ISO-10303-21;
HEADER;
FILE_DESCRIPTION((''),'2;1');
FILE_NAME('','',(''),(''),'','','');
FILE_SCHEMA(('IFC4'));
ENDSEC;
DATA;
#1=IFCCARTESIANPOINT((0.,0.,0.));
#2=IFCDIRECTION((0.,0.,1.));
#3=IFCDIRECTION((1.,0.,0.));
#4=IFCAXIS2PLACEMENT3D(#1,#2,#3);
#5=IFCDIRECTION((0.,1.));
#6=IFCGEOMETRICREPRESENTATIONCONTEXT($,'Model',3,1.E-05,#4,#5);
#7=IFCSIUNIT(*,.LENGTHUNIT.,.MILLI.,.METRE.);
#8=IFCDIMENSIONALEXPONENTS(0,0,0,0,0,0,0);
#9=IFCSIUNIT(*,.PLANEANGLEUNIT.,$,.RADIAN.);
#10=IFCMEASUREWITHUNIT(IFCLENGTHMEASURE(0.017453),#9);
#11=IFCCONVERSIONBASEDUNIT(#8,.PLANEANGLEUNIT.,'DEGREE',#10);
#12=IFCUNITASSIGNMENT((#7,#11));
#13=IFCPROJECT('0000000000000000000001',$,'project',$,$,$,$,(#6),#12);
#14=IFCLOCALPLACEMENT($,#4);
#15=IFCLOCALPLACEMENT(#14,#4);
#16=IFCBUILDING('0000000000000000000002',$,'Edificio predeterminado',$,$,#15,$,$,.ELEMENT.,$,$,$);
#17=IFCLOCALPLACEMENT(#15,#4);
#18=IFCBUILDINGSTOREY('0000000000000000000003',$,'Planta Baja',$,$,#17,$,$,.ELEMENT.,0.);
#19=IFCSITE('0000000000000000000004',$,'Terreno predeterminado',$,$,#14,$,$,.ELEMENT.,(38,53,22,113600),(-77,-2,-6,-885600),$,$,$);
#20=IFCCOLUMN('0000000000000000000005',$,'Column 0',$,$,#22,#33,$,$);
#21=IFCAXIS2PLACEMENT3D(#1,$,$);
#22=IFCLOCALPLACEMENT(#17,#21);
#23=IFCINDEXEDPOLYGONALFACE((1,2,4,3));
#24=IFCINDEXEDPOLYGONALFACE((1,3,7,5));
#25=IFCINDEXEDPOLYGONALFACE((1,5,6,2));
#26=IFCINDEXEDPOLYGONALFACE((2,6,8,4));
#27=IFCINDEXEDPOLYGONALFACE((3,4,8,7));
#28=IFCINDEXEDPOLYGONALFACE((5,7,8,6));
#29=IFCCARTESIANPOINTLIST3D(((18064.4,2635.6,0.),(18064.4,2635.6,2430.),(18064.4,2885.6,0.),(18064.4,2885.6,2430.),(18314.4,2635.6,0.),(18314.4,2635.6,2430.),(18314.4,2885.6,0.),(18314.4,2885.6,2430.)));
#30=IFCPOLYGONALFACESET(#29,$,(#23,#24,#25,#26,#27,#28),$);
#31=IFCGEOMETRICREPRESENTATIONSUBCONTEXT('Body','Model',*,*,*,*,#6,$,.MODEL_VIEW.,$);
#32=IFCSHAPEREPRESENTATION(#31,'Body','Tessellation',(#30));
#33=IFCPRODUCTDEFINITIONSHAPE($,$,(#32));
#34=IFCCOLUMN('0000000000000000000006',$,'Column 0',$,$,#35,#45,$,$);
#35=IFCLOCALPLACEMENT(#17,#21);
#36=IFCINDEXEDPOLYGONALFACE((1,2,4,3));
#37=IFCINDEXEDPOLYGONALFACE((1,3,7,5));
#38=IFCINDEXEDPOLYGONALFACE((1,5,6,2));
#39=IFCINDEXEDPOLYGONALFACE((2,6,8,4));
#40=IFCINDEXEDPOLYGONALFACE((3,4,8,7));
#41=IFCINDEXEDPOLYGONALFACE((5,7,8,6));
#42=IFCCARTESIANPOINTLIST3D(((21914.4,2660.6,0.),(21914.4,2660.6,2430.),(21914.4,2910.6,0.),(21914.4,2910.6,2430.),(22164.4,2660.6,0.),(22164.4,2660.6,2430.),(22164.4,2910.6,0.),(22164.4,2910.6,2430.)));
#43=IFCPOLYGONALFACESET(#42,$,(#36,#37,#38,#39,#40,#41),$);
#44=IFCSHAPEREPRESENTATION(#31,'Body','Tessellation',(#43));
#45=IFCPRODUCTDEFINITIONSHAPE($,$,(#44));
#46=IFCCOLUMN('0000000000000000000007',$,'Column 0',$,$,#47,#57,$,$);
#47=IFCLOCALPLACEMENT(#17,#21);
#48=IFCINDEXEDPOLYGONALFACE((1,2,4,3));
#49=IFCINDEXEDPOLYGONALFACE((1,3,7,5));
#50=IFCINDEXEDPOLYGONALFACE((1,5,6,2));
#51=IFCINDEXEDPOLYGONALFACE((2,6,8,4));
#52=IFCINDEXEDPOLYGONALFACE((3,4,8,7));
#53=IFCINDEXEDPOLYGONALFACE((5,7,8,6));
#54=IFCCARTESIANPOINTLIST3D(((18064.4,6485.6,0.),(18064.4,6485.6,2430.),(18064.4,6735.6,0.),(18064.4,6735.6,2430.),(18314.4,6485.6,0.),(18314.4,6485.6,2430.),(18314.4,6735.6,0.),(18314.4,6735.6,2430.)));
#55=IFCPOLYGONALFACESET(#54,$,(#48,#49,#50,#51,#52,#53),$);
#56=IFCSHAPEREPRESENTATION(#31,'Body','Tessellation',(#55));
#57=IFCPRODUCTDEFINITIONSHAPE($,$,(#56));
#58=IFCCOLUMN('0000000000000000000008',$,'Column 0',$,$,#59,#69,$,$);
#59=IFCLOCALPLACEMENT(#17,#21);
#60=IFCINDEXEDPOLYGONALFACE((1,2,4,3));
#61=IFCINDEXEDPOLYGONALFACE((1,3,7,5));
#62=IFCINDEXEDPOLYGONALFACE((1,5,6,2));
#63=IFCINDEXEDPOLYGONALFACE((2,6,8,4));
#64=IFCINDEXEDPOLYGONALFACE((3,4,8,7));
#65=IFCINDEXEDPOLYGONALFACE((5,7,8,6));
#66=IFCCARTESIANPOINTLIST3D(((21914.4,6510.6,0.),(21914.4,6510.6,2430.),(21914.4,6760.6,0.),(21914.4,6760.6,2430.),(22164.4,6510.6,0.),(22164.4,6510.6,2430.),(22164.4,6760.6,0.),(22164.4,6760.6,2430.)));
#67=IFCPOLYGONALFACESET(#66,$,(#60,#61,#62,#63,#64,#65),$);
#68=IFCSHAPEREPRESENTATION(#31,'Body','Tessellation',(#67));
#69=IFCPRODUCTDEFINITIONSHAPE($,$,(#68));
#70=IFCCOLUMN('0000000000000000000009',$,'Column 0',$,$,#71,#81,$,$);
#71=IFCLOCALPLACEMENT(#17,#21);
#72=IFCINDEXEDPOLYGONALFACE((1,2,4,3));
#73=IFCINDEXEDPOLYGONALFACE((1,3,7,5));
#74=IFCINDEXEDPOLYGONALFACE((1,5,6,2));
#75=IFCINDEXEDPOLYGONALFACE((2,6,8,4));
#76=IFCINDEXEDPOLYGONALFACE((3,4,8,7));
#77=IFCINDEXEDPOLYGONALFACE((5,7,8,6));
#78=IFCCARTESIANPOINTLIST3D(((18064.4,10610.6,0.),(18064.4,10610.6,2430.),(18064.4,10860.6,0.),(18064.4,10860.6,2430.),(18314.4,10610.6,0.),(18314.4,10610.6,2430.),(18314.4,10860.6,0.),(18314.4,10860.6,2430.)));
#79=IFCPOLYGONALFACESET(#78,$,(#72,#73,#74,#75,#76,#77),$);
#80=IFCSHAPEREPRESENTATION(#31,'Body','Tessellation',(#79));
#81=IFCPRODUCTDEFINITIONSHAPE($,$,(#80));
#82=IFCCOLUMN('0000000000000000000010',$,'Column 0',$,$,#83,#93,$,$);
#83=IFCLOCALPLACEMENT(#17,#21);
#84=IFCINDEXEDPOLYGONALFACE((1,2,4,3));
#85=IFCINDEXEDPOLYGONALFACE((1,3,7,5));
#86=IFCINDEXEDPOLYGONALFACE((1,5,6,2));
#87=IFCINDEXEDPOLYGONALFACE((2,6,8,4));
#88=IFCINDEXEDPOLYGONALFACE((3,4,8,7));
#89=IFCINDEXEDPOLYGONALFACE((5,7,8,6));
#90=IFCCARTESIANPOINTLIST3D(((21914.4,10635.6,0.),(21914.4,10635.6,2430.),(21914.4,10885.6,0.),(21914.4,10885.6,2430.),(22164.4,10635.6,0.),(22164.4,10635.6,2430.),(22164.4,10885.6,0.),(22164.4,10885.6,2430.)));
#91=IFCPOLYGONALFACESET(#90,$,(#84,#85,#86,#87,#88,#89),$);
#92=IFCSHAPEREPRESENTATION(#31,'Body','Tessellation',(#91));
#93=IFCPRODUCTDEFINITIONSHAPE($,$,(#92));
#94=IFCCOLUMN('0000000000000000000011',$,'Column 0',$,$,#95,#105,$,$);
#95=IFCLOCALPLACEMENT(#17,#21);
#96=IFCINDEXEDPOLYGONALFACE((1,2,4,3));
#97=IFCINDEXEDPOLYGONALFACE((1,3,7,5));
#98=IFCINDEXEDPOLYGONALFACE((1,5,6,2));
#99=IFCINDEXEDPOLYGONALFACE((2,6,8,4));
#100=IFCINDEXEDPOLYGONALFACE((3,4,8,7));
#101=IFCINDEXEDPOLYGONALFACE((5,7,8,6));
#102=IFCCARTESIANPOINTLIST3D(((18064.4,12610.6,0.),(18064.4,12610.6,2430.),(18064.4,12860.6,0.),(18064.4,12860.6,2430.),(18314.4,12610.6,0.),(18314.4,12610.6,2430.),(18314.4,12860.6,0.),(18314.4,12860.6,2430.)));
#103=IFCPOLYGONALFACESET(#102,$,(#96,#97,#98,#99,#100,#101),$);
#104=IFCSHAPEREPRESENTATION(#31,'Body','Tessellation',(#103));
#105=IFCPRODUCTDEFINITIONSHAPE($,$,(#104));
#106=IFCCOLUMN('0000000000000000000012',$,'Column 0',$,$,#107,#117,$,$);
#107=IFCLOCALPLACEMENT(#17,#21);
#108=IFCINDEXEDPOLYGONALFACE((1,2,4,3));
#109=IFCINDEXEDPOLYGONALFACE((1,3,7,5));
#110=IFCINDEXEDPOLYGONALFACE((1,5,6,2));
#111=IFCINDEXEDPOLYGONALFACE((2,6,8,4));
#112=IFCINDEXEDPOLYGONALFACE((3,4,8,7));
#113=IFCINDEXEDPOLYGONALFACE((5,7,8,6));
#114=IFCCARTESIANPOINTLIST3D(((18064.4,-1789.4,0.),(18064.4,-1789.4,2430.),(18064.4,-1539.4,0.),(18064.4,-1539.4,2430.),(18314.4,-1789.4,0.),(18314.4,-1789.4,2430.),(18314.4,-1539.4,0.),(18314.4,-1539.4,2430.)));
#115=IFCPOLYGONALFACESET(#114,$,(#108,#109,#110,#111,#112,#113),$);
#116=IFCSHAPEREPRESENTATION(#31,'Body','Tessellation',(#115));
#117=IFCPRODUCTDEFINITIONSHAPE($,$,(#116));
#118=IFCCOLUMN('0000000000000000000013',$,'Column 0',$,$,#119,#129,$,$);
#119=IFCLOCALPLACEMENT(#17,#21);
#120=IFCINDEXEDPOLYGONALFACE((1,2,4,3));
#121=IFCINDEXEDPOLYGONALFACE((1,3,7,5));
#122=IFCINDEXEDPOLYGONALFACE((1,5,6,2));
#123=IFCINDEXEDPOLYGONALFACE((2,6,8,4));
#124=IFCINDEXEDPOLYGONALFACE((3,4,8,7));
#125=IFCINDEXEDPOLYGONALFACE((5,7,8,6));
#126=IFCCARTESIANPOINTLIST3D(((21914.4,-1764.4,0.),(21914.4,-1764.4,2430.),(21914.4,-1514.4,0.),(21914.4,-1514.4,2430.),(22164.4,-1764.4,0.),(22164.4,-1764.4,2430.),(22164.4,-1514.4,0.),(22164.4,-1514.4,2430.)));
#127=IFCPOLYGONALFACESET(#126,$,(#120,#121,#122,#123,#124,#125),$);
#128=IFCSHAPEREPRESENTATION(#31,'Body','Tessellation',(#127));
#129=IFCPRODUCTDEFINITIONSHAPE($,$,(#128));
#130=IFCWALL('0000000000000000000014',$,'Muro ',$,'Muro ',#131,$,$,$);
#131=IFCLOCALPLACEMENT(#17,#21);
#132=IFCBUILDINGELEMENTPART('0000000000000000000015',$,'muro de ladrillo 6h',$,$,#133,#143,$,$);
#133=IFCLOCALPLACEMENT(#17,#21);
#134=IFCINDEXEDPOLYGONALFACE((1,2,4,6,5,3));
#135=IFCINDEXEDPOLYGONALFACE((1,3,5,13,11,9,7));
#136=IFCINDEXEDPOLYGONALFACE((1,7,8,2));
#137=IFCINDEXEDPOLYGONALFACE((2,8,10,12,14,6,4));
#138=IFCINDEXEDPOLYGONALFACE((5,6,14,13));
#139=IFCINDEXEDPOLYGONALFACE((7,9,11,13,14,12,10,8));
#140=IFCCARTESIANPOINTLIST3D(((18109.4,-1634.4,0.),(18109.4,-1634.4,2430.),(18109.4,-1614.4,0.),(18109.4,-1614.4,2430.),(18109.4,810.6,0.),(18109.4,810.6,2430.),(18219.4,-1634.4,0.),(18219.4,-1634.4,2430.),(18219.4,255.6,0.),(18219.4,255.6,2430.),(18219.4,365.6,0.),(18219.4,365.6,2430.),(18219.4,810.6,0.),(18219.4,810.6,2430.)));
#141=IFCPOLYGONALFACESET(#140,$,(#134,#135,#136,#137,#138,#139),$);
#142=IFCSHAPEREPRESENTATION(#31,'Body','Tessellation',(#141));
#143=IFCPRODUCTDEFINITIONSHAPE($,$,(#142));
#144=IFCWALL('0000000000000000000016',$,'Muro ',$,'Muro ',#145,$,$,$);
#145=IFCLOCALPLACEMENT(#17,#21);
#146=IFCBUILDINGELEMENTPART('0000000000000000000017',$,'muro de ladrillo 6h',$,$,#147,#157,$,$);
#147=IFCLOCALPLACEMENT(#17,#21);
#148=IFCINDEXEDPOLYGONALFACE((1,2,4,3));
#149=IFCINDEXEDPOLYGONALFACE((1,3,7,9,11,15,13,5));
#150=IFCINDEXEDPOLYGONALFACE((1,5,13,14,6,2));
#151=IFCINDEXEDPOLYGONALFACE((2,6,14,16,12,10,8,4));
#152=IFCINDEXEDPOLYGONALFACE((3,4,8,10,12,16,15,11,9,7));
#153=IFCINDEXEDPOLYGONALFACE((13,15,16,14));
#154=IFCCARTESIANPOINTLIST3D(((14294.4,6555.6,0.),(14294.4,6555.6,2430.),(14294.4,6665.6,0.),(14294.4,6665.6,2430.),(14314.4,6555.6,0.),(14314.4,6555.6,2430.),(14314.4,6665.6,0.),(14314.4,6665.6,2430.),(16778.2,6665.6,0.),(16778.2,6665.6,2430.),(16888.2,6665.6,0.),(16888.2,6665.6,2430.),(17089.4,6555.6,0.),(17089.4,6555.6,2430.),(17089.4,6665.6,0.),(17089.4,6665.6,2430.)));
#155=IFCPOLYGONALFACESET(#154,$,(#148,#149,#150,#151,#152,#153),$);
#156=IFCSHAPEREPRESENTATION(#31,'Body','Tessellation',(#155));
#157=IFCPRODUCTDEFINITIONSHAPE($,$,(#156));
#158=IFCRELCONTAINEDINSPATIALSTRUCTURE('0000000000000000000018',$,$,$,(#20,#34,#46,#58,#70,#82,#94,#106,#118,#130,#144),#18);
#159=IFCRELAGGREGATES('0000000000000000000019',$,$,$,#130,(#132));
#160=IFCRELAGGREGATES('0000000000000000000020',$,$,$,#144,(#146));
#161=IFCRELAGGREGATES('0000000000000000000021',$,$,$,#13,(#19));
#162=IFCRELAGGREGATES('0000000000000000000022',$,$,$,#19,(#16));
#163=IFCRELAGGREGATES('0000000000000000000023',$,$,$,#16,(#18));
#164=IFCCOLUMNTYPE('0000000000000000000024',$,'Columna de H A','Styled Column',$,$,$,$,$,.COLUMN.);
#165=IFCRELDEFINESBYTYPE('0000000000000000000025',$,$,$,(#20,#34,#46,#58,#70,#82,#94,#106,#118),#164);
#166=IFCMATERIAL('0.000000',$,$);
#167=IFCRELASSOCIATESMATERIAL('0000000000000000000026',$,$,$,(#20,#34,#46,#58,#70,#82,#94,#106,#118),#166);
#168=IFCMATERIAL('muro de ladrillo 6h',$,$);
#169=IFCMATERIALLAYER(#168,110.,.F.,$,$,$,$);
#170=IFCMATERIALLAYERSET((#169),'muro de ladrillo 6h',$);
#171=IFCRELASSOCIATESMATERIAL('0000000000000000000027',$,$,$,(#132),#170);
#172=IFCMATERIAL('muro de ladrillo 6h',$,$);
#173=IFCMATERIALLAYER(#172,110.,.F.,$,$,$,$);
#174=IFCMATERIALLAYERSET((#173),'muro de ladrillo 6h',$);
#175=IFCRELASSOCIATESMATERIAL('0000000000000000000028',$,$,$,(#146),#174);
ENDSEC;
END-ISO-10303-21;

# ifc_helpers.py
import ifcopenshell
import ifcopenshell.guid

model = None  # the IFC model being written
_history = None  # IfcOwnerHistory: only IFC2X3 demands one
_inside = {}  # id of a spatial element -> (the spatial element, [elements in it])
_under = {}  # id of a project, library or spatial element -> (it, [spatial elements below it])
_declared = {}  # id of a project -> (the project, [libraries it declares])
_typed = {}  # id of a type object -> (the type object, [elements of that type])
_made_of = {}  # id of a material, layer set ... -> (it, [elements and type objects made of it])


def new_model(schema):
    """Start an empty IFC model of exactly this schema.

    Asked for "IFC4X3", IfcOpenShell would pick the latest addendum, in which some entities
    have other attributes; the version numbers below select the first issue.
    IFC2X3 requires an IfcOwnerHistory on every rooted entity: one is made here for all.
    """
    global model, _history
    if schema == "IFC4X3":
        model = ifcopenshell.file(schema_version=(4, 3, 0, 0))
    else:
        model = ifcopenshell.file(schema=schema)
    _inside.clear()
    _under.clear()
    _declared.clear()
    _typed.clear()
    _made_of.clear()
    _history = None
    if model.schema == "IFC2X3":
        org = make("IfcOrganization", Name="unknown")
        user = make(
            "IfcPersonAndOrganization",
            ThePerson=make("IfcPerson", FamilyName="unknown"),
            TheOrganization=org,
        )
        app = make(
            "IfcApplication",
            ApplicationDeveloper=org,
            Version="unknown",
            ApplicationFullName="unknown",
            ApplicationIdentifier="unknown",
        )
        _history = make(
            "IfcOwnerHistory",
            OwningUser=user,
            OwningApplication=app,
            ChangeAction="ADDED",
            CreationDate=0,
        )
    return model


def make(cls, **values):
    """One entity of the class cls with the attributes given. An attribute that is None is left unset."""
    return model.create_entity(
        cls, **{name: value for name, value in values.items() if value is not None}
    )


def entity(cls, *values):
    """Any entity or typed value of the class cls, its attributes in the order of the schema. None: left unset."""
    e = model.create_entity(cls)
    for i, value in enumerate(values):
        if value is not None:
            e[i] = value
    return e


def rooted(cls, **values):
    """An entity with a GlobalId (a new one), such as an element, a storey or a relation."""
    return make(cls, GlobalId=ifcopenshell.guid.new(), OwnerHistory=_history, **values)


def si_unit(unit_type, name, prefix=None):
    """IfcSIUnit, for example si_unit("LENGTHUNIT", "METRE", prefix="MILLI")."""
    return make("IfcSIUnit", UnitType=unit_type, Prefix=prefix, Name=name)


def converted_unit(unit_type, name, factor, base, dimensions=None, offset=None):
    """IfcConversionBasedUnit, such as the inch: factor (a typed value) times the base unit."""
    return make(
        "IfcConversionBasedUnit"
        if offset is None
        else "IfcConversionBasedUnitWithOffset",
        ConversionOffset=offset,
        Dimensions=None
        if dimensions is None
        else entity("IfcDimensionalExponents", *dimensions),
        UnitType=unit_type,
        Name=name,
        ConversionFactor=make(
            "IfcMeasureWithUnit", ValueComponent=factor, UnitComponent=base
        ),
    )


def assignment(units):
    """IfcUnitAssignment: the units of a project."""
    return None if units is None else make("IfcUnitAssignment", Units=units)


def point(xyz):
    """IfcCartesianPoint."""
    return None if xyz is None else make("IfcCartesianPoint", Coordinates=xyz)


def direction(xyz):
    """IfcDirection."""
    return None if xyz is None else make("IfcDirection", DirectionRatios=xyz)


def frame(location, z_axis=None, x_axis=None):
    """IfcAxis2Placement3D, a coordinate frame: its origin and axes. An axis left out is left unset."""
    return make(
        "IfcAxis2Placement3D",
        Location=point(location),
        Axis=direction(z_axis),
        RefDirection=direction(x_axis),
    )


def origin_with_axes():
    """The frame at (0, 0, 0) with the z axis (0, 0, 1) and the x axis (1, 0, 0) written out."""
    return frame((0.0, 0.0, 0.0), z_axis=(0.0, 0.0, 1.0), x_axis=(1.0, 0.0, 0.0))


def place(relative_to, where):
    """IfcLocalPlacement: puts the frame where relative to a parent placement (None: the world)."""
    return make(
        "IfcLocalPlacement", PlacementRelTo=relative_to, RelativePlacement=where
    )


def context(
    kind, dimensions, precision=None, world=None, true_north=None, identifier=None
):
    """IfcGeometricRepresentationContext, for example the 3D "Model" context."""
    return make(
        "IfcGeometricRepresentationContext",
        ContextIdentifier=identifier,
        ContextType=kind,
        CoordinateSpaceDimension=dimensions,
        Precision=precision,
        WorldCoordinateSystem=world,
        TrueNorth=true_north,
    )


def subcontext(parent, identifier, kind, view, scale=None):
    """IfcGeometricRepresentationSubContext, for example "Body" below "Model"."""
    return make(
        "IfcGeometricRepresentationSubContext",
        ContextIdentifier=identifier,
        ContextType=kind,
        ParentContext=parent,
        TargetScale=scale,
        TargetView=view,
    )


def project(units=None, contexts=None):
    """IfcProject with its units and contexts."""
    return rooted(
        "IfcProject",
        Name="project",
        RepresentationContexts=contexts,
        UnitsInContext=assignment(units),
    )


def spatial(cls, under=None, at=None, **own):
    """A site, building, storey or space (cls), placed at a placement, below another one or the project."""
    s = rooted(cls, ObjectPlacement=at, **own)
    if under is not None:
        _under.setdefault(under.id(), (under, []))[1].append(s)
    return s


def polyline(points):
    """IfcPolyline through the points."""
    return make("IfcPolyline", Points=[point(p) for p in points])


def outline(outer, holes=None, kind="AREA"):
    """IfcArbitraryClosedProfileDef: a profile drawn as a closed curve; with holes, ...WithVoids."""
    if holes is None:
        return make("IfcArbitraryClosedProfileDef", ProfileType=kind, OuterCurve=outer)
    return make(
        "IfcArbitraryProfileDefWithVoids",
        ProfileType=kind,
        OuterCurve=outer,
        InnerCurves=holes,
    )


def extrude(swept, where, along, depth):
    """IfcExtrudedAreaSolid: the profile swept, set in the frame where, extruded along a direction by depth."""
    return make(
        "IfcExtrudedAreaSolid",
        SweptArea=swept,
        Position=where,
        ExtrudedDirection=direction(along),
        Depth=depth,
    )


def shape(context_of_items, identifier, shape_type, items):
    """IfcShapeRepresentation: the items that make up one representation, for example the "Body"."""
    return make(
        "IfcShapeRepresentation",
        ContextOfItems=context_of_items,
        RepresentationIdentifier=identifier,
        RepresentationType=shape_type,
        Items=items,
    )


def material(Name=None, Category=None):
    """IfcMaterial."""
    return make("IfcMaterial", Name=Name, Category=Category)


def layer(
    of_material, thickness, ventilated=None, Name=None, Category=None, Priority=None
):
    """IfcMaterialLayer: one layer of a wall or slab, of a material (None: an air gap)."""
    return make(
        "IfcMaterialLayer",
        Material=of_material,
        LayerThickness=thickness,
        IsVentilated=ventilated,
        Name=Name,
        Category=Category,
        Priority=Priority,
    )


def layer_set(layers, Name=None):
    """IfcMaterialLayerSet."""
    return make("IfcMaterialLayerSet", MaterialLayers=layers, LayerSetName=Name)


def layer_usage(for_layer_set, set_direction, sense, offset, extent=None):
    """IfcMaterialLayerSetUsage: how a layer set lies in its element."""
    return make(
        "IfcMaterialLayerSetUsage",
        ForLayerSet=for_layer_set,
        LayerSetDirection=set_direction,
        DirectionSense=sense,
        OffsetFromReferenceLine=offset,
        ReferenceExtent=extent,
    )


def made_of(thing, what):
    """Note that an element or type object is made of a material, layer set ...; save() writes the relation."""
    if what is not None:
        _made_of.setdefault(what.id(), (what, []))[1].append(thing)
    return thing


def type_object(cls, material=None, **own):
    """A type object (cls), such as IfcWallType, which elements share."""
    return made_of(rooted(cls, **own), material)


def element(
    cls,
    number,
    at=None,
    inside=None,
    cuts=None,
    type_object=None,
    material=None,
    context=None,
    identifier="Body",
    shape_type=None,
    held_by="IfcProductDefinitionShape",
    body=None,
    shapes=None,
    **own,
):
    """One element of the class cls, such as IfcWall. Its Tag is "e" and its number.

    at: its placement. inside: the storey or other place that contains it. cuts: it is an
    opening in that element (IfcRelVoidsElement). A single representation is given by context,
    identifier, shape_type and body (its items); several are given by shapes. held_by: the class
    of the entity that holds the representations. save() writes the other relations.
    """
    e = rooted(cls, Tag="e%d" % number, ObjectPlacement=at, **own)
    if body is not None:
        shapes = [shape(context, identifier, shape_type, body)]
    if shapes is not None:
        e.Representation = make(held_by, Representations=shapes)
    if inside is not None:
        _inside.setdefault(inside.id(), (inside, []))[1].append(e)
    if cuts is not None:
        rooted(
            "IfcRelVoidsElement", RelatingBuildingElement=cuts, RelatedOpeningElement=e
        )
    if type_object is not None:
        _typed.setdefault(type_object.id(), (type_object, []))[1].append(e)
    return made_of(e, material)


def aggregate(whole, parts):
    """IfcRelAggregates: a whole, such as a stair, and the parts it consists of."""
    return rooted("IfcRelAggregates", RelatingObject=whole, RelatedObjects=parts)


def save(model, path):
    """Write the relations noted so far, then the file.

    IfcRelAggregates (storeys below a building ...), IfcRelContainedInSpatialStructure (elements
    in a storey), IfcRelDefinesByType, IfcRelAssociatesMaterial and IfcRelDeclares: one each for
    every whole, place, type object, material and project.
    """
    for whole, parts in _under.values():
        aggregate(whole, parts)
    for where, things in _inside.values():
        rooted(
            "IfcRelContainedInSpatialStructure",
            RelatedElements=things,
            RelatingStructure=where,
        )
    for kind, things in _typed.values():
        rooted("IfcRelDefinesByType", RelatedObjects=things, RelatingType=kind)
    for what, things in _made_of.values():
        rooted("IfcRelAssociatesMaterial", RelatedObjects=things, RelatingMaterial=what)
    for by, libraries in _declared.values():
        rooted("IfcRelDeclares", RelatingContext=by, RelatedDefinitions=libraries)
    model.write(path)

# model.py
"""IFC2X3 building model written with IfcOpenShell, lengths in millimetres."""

from ifc_helpers import new_model, entity, si_unit, converted_unit, direction, frame, origin_with_axes, place, context, subcontext, project, spatial, polyline, outline, extrude, material, layer, layer_set, layer_usage, type_object, element, aggregate, save


model = new_model("IFC2X3")

# Units and contexts
model_context = context("Model", 3, precision=1e-05, world=origin_with_axes(), true_north=direction((0.0, 1.0)))
body_context = subcontext(model_context, "Body", "Model", "MODEL_VIEW")
ifc_project = project(units=[si_unit("LENGTHUNIT", "METRE", prefix="MILLI"), converted_unit("PLANEANGLEUNIT", "DEGREE", entity("IfcLengthMeasure", 0.017453), si_unit("PLANEANGLEUNIT", "RADIAN"), dimensions=[0, 0, 0, 0, 0, 0, 0])], contexts=[model_context])

# Site, building, storey
site_placement = place(None, origin_with_axes())
site = spatial("IfcSite", under=ifc_project, at=site_placement, Name="Terreno predeterminado", CompositionType="ELEMENT", RefLatitude=(38, 53, 22, 113600), RefLongitude=(-77, -2, -6, -885600))
building_placement = place(site_placement, origin_with_axes())
building = spatial("IfcBuilding", under=site, at=building_placement, Name="Edificio predeterminado", CompositionType="ELEMENT")
storey_placement = place(building_placement, origin_with_axes())
storey = spatial("IfcBuildingStorey", under=building, at=storey_placement, Name="Planta Baja", CompositionType="ELEMENT", Elevation=0.0)

# Columns
ifc_material_1 = material(Name="0.000000")
column_type = type_object("IfcColumnType", Name="Columna de H A", Description="Styled Column", PredefinedType="COLUMN")
for number, where, z_axis, x_axis, name in (
    (1, (18189.4, 2760.6, 0.0), (0.0, 0.0, 1.0), (1.0, 0.0, 0.0), "Column 0"),
    (2, (22039.4, 2785.6, 0.0), (0.0, 0.0, 1.0), (1.0, 0.0, 0.0), "Column 0"),
    (3, (18189.4, 6610.6, 0.0), (0.0, 0.0, 1.0), (1.0, 0.0, 0.0), "Column 0"),
    (4, (22039.4, 6635.6, 0.0), (0.0, 0.0, 1.0), (1.0, 0.0, 0.0), "Column 0"),
    (5, (18189.4, 10735.6, 0.0), (0.0, 0.0, 1.0), (1.0, 0.0, 0.0), "Column 0"),
    (6, (22039.4, 10760.6, 0.0), (0.0, 0.0, 1.0), (1.0, 0.0, 0.0), "Column 0"),
    (7, (18189.4, 12735.6, 0.0), (0.0, 0.0, 1.0), (1.0, 0.0, 0.0), "Column 0"),
    (8, (18189.4, -1664.4, 0.0), (0.0, 0.0, 1.0), (1.0, 0.0, 0.0), "Column 0"),
    (9, (22039.4, -1639.4, 0.0), (0.0, 0.0, 1.0), (1.0, 0.0, 0.0), "Column 0"),
):
    element("IfcColumn", number, at=place(storey_placement, frame(where, z_axis=z_axis, x_axis=x_axis)), inside=storey, type_object=column_type, material=ifc_material_1, Name=name, context=body_context, shape_type="SweptSolid", body=[
        extrude(outline(polyline([(-125.0, -125.0), (125.0, -125.0), (125.0, 125.0), (-125.0, 125.0), (-125.0, -125.0)])), origin_with_axes(), (0.0, 0.0, 1.0), 2430.0),
    ])

# Walls, building element parts
wall_1_placement = place(storey_placement, frame((18164.4, 810.6, 0.0), z_axis=(0.0, 0.0, 1.0), x_axis=(0.0, -1.0, 0.0)))
wall_1 = element("IfcWall", 10, at=wall_1_placement, inside=storey, Name="Muro ", ObjectType="Muro ")
ifc_material_2 = material(Name="muro de ladrillo 6h")
ifc_layer_1 = layer(ifc_material_2, 110.0, ventilated=False)
ifc_layer_set_1 = layer_set([ifc_layer_1], Name="muro de ladrillo 6h")
ifc_layer_usage_1 = layer_usage(ifc_layer_set_1, "AXIS2", "NEGATIVE", -55.0)
building_element_part_1_placement = place(wall_1_placement, origin_with_axes())
building_element_part_1 = element("IfcBuildingElementPart", 11, at=building_element_part_1_placement, material=ifc_layer_usage_1, Name="muro de ladrillo 6h", context=body_context, shape_type="SweptSolid", body=[
    extrude(outline(polyline([(2445.0, 55.0), (2445.0, -55.0), (2425.0, -55.0), (0.0, -55.0), (0.0, 55.0), (445.0, 55.0), (555.0, 55.0), (2445.0, 55.0)])), origin_with_axes(), (0.0, 0.0, 1.0), 2430.0),
])
aggregate(wall_1, [building_element_part_1])
wall_2_placement = place(storey_placement, frame((17089.4, 6610.6, 0.0), z_axis=(0.0, 0.0, 1.0), x_axis=(-1.0, 0.0, 0.0)))
wall_2 = element("IfcWall", 12, at=wall_2_placement, inside=storey, Name="Muro ", ObjectType="Muro ")
ifc_material_3 = material(Name="muro de ladrillo 6h")
ifc_layer_2 = layer(ifc_material_3, 110.0, ventilated=False)
ifc_layer_set_2 = layer_set([ifc_layer_2], Name="muro de ladrillo 6h")
ifc_layer_usage_2 = layer_usage(ifc_layer_set_2, "AXIS2", "NEGATIVE", -55.0)
building_element_part_2_placement = place(wall_2_placement, origin_with_axes())
building_element_part_2 = element("IfcBuildingElementPart", 13, at=building_element_part_2_placement, material=ifc_layer_usage_2, Name="muro de ladrillo 6h", context=body_context, shape_type="SweptSolid", body=[
    extrude(outline(polyline([(0.0, 55.0), (2775.0, 55.0), (2795.0, 55.0), (2795.0, -55.0), (2775.0, -55.0), (311.1, -55.0), (201.1, -55.0), (0.0, -55.0), (0.0, 55.0)])), origin_with_axes(), (0.0, 0.0, 1.0), 2430.0),
])
aggregate(wall_2, [building_element_part_2])

save(model, "model.ifc")
